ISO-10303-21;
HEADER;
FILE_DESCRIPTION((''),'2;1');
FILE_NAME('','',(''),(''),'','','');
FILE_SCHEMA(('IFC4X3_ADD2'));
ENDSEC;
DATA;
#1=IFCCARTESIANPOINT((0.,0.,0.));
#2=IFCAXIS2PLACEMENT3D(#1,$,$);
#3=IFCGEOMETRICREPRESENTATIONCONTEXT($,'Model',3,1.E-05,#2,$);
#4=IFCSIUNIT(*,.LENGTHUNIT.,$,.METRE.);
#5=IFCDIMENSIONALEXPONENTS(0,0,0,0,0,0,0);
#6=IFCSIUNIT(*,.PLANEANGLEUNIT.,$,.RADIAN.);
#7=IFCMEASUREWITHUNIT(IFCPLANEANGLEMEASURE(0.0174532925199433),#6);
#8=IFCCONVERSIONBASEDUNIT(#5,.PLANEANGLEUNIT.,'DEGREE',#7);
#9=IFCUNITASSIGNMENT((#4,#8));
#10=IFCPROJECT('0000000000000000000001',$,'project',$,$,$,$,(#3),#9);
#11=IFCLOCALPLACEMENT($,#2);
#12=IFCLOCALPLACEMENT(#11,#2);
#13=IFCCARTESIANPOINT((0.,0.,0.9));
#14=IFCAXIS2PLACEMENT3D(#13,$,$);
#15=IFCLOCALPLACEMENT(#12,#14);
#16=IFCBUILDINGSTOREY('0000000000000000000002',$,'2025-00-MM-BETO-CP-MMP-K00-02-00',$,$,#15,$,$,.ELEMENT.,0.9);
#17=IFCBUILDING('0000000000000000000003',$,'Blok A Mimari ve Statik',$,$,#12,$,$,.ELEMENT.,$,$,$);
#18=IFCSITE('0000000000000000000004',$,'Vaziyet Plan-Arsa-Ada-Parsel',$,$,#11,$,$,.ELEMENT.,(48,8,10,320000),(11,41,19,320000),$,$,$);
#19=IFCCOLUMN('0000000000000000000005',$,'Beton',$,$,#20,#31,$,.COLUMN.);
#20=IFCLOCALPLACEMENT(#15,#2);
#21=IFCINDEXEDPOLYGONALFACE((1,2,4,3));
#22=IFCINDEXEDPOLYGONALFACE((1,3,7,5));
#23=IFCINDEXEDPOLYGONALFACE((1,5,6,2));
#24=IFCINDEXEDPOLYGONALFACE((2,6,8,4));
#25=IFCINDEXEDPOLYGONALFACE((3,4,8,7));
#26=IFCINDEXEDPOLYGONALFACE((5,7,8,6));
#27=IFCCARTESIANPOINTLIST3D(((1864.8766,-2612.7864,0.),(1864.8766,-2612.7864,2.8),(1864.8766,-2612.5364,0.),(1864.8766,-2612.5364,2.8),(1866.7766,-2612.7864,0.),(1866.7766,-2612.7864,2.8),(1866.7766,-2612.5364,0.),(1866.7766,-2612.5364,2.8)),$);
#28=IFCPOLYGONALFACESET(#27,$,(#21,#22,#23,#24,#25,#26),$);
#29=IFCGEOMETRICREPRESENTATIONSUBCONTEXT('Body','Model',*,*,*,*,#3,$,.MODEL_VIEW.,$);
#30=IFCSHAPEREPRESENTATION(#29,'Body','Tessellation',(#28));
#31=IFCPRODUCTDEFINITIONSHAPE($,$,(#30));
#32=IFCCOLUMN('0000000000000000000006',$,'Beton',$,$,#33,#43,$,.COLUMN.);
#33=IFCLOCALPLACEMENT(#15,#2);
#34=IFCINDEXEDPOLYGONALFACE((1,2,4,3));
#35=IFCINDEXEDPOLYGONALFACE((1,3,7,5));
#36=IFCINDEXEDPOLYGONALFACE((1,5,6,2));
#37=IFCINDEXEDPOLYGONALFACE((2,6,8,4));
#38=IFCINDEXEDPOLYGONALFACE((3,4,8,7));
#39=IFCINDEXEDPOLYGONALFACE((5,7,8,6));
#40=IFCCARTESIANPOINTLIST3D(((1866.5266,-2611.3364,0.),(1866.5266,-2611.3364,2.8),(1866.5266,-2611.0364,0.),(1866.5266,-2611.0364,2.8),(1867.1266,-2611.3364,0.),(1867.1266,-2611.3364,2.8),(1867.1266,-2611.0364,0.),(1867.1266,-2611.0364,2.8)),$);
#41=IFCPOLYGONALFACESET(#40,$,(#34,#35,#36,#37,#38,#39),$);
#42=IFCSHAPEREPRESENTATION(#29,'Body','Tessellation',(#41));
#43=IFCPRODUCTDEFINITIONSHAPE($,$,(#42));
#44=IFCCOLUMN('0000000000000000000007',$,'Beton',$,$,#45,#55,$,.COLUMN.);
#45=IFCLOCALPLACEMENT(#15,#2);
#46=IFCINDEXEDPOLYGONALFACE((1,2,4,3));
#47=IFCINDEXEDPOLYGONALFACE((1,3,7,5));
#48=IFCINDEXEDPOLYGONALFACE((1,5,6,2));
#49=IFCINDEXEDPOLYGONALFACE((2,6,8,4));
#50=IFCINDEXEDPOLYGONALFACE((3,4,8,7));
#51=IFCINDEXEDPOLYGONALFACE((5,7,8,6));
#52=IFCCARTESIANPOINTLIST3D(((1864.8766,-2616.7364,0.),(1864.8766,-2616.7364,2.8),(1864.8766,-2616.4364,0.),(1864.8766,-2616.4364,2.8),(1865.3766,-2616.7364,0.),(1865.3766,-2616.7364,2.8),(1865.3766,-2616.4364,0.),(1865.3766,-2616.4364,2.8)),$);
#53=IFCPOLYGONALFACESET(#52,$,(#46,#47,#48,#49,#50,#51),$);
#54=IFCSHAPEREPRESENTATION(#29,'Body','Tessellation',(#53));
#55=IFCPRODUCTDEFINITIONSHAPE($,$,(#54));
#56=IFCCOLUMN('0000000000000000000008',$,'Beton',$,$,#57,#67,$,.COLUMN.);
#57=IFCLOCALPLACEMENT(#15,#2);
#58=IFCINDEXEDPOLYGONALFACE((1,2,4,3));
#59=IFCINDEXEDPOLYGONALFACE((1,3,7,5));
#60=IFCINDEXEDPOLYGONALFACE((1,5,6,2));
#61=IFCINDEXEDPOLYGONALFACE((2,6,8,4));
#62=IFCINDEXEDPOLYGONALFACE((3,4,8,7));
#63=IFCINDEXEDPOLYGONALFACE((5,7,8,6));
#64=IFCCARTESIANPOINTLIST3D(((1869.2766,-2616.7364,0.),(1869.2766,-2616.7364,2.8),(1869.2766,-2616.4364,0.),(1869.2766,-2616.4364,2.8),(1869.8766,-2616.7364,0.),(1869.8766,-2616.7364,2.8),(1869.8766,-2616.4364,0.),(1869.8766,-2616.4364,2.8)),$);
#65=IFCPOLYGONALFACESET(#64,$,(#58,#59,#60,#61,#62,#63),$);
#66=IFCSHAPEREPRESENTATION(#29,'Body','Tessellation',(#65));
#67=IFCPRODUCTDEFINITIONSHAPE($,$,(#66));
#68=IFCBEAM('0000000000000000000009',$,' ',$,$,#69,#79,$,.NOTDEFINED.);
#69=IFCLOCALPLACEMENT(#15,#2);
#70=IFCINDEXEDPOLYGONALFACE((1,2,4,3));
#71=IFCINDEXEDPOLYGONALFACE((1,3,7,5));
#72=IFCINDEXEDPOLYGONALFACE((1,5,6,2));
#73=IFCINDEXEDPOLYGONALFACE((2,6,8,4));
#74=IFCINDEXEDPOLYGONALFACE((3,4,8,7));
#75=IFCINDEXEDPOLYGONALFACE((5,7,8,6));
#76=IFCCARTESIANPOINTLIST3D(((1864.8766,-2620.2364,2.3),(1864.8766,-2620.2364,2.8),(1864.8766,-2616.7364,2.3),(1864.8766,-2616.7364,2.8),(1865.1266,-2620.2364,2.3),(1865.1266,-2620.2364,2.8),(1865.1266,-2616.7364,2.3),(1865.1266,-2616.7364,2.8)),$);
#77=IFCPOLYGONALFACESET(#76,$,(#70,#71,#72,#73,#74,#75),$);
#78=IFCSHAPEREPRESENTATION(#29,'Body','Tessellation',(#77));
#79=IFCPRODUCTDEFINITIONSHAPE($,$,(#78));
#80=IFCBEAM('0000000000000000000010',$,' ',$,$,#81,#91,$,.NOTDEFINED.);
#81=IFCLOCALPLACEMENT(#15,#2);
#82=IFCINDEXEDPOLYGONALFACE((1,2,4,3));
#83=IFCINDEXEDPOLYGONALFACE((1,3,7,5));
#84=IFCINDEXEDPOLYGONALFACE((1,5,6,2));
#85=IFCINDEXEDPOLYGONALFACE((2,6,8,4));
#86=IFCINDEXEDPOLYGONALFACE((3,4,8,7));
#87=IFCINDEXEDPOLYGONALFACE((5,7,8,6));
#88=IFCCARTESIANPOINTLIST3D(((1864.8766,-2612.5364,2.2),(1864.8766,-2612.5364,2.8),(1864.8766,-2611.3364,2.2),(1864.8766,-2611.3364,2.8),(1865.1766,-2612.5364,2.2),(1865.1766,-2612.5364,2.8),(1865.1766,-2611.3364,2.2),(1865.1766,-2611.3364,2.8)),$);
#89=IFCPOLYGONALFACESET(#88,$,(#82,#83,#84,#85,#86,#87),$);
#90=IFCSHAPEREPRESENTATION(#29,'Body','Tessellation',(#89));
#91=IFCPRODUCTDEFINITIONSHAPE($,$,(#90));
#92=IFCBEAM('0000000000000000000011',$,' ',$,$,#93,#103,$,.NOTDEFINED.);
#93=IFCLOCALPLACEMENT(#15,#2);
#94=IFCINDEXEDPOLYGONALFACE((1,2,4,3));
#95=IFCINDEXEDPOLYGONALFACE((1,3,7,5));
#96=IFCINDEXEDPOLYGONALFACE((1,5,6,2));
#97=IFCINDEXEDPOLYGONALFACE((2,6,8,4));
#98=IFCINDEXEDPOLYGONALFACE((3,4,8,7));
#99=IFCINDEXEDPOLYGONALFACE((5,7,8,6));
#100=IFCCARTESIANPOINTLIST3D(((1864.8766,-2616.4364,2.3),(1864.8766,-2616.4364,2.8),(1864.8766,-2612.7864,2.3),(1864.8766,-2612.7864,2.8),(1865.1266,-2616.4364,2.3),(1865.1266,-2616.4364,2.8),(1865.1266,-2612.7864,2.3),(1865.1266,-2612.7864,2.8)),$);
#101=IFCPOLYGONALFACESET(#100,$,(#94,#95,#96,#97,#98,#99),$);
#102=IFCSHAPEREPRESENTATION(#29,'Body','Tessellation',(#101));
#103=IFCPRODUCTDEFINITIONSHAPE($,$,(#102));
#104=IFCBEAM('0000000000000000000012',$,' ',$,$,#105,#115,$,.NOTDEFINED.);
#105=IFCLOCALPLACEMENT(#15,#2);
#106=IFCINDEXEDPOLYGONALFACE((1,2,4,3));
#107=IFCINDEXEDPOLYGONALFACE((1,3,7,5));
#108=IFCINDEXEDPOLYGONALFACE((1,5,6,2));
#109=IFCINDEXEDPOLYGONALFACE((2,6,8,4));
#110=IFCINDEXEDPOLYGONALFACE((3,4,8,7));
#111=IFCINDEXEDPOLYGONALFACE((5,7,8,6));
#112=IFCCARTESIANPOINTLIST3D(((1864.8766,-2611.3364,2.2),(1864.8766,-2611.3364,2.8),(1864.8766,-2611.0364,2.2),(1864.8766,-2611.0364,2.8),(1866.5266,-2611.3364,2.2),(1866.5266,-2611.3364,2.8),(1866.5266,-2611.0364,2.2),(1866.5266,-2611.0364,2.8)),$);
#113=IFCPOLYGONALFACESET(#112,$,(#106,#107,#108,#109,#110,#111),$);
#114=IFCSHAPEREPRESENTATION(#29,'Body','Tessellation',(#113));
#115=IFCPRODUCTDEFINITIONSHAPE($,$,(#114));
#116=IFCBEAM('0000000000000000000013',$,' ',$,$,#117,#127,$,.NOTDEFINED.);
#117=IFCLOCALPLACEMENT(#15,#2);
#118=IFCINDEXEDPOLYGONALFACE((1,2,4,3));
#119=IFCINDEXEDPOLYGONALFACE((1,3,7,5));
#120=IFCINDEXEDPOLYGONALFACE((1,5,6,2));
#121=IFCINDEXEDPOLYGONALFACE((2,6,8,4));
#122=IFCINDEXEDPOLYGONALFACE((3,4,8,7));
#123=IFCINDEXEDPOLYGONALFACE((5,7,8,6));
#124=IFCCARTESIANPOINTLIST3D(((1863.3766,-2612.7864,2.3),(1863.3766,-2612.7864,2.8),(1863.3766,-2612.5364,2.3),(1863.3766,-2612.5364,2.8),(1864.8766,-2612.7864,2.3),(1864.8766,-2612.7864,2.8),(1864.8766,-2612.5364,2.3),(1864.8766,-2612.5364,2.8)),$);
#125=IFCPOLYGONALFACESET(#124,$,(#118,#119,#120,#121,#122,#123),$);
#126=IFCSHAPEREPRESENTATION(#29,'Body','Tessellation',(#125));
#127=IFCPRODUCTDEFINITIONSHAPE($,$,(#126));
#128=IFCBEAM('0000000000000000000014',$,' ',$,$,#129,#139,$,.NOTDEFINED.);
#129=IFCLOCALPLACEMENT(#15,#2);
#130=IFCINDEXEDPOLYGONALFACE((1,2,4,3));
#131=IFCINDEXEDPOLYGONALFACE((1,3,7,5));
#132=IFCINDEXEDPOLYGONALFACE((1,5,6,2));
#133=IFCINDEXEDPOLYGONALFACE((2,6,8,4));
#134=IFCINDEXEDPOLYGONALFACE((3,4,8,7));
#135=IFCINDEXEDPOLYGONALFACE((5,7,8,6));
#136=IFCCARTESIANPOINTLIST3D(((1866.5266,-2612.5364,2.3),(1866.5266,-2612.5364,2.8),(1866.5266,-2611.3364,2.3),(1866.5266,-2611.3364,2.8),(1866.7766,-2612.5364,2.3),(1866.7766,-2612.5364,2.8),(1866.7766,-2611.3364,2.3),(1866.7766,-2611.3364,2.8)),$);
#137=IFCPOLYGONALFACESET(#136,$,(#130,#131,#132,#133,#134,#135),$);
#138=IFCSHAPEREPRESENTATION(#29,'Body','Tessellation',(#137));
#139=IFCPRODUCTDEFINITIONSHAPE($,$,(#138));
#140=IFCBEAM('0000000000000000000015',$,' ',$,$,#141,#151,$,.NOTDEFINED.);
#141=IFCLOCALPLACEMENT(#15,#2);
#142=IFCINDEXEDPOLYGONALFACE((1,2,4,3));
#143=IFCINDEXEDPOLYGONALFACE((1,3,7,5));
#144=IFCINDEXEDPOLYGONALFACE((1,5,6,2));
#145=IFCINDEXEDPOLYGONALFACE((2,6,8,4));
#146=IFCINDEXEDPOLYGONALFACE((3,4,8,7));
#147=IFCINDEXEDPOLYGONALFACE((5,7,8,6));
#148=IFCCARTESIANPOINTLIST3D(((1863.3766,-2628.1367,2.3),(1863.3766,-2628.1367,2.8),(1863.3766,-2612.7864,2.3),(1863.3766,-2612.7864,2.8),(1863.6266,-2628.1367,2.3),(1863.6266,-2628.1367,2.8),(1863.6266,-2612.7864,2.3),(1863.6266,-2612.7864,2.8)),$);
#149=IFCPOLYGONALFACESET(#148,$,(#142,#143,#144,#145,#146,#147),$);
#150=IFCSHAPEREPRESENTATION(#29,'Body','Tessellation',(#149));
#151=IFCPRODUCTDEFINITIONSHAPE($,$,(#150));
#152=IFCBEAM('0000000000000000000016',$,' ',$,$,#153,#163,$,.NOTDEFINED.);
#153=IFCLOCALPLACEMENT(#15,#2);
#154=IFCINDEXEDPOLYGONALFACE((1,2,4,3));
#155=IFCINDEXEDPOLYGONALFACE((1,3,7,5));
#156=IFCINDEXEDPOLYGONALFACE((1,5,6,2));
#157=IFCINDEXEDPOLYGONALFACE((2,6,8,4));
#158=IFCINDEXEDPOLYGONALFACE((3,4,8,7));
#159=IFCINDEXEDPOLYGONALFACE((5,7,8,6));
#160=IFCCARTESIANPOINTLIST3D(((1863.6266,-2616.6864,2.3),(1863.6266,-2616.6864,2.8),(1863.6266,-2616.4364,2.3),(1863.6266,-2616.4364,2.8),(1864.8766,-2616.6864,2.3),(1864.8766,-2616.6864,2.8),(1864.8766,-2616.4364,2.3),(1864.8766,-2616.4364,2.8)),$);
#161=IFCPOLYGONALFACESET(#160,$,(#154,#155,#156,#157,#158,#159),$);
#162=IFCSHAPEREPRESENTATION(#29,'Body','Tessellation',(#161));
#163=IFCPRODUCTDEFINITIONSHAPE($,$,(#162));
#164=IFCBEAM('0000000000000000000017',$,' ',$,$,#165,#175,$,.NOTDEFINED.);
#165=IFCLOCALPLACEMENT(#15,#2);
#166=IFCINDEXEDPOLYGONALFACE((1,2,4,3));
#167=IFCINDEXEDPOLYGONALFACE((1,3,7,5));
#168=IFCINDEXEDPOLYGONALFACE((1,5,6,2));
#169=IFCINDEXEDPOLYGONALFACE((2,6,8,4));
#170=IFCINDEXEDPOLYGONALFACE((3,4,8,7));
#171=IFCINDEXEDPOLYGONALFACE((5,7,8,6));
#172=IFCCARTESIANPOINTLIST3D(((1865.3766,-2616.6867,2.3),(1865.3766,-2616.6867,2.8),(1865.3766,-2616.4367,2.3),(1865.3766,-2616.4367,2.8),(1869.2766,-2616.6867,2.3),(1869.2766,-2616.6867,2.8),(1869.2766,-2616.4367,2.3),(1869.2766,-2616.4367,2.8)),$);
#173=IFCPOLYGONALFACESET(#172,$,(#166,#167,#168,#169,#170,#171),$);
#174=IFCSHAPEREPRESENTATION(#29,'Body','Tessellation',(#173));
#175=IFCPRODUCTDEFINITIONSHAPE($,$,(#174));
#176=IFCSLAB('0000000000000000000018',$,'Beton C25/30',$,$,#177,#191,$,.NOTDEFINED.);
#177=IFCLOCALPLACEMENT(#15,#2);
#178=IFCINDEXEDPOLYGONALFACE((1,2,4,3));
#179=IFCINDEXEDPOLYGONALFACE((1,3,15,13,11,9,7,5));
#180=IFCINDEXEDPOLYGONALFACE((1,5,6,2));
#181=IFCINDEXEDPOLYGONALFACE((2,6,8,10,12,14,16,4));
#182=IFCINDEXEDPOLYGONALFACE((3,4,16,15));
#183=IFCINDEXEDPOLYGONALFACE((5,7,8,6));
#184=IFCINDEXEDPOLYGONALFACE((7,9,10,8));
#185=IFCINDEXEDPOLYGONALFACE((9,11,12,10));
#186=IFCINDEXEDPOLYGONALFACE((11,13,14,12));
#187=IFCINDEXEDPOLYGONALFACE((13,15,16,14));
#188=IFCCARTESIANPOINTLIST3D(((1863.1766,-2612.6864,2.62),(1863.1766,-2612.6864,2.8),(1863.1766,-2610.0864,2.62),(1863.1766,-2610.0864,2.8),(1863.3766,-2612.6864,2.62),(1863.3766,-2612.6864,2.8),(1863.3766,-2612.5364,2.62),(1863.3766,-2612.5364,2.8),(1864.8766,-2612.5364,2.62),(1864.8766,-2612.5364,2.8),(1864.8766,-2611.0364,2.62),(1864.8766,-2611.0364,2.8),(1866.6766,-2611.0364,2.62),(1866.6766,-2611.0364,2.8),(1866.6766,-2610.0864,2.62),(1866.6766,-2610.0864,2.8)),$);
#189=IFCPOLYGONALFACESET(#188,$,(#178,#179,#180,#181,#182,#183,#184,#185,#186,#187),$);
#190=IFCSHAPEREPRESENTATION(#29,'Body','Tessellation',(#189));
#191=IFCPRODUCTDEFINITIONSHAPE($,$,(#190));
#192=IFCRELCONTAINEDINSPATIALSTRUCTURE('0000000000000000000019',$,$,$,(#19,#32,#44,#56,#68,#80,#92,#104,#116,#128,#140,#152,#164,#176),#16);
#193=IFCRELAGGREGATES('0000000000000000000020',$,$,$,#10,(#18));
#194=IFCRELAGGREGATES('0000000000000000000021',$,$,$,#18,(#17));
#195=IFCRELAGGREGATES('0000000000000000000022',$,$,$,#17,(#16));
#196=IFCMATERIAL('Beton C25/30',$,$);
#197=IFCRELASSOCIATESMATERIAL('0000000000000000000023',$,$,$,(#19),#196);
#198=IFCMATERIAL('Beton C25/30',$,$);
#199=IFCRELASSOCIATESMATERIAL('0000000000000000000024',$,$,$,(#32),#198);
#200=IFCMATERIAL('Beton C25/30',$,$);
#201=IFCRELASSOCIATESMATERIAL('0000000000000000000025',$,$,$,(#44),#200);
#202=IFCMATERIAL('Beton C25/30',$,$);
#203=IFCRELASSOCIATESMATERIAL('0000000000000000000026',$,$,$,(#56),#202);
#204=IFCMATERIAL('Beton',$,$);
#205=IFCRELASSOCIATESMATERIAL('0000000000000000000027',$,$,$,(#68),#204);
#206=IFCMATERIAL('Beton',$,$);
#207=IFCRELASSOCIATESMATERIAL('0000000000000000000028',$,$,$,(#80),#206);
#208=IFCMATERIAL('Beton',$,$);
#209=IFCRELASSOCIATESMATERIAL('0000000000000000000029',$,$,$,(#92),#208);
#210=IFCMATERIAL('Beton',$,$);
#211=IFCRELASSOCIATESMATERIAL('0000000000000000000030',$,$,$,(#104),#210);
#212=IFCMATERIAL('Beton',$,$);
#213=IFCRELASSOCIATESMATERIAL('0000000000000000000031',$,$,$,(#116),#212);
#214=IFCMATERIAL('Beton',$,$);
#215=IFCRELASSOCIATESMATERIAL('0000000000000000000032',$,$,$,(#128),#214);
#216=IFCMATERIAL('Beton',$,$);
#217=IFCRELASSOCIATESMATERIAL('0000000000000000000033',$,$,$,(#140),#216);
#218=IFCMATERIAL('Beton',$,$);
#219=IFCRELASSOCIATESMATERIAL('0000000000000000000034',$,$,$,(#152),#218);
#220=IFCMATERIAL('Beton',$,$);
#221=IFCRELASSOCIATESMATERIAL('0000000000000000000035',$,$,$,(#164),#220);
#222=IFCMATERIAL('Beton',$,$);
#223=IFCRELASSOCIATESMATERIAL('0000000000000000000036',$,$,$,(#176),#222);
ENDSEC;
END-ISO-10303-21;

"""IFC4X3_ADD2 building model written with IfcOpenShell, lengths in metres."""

from ifc_helpers import new_model, entity, si_unit, converted_unit, frame, frame_2d, origin, origin_with_axes, place, context, subcontext, project, spatial, polyline, rectangle, outline, extrude, material, element, save


model = new_model("IFC4X3_ADD2")

# Units and contexts
model_context = context("Model", 3, precision=1e-05, world=origin())
body_context = subcontext(model_context, "Body", "Model", "MODEL_VIEW")
ifc_project = project(units=[si_unit("LENGTHUNIT", "METRE"), converted_unit("PLANEANGLEUNIT", "DEGREE", entity("IfcPlaneAngleMeasure", 0.0174532925199433), si_unit("PLANEANGLEUNIT", "RADIAN"), dimensions=[0, 0, 0, 0, 0, 0, 0])], contexts=[model_context])

# Site, building, storey
site_placement = place(None, origin())
site = spatial("IfcSite", under=ifc_project, at=site_placement, Name="Vaziyet Plan-Arsa-Ada-Parsel", CompositionType="ELEMENT", RefLatitude=(48, 8, 10, 320000), RefLongitude=(11, 41, 19, 320000))
building_placement = place(site_placement, origin())
building = spatial("IfcBuilding", under=site, at=building_placement, Name="Blok A Mimari ve Statik", CompositionType="ELEMENT")
storey_placement = place(building_placement, frame((0.0, 0.0, 0.9)))
storey = spatial("IfcBuildingStorey", under=building, at=storey_placement, Name="2025-00-MM-BETO-CP-MMP-K00-02-00", CompositionType="ELEMENT", Elevation=0.9)

# Columns
ifc_material_1 = material(Name="Beton C25/30")
column_1_placement = place(storey_placement, frame((1864.8766, -2612.7864, 0.0)))
element("IfcColumn", 1, at=column_1_placement, inside=storey, material=ifc_material_1, Name="Beton", PredefinedType="COLUMN", context=body_context, shape_type="SweptSolid", body=[
    extrude(outline(polyline([(0.0, 0.0), (1.9, 0.0), (1.9, 0.25), (0.0, 0.25), (0.0, 0.0)])), origin_with_axes(), (0.0, 0.0, 1.0), 2.8),
])
ifc_material_2 = material(Name="Beton C25/30")
column_2_placement = place(storey_placement, frame((1866.5266, -2611.3364, 0.0)))
element("IfcColumn", 2, at=column_2_placement, inside=storey, material=ifc_material_2, Name="Beton", PredefinedType="COLUMN", context=body_context, shape_type="SweptSolid", body=[
    extrude(outline(polyline([(0.0, 0.0), (0.6, 0.0), (0.6, 0.3), (0.0, 0.3), (0.0, 0.0)])), origin_with_axes(), (0.0, 0.0, 1.0), 2.8),
])
ifc_material_3 = material(Name="Beton C25/30")
column_3_placement = place(storey_placement, frame((1864.8766, -2616.7364, 0.0)))
element("IfcColumn", 3, at=column_3_placement, inside=storey, material=ifc_material_3, Name="Beton", PredefinedType="COLUMN", context=body_context, shape_type="SweptSolid", body=[
    extrude(outline(polyline([(0.0, 0.0), (0.5, 0.0), (0.5, 0.3), (0.0, 0.3), (0.0, 0.0)])), origin_with_axes(), (0.0, 0.0, 1.0), 2.8),
])
ifc_material_4 = material(Name="Beton C25/30")
column_4_placement = place(storey_placement, frame((1869.2766, -2616.7364, 0.0)))
element("IfcColumn", 4, at=column_4_placement, inside=storey, material=ifc_material_4, Name="Beton", PredefinedType="COLUMN", context=body_context, shape_type="SweptSolid", body=[
    extrude(outline(polyline([(0.0, 0.0), (0.6, 0.0), (0.6, 0.3), (0.0, 0.3), (0.0, 0.0)])), origin_with_axes(), (0.0, 0.0, 1.0), 2.8),
])

# Beams
ifc_material_5 = material(Name="Beton")
beam_1_placement = place(storey_placement, frame((1864.8766, -2616.7364, 2.3), z_axis=(0.0, 0.0, 1.0), x_axis=(0.0, -1.0, 0.0)))
element("IfcBeam", 5, at=beam_1_placement, inside=storey, material=ifc_material_5, Name=" ", PredefinedType="NOTDEFINED", context=body_context, shape_type="SweptSolid", body=[
    extrude(rectangle(XDim=0.25, YDim=0.5, at=frame_2d((0.125, 0.25), x_axis=(1.0, 0.0))), frame((0.0, 0.0, 0.0), z_axis=(1.0, 0.0, 0.0), x_axis=(0.0, 1.0, 0.0)), (0.0, 0.0, 1.0), 3.5),
])
ifc_material_6 = material(Name="Beton")
beam_2_placement = place(storey_placement, frame((1864.8766, -2611.3364, 2.2), z_axis=(0.0, 0.0, 1.0), x_axis=(0.0, -1.0, 0.0)))
element("IfcBeam", 6, at=beam_2_placement, inside=storey, material=ifc_material_6, Name=" ", PredefinedType="NOTDEFINED", context=body_context, shape_type="SweptSolid", body=[
    extrude(rectangle(XDim=0.3, YDim=0.6, at=frame_2d((0.15, 0.3), x_axis=(1.0, 0.0))), frame((0.0, 0.0, 0.0), z_axis=(1.0, 0.0, 0.0), x_axis=(0.0, 1.0, 0.0)), (0.0, 0.0, 1.0), 1.2),
])
ifc_material_7 = material(Name="Beton")
beam_3_placement = place(storey_placement, frame((1864.8766, -2612.7864, 2.3), z_axis=(0.0, 0.0, 1.0), x_axis=(0.0, -1.0, 0.0)))
element("IfcBeam", 7, at=beam_3_placement, inside=storey, material=ifc_material_7, Name=" ", PredefinedType="NOTDEFINED", context=body_context, shape_type="SweptSolid", body=[
    extrude(rectangle(XDim=0.25, YDim=0.5, at=frame_2d((0.125, 0.25), x_axis=(1.0, 0.0))), frame((0.0, 0.0, 0.0), z_axis=(1.0, 0.0, 0.0), x_axis=(0.0, 1.0, 0.0)), (0.0, 0.0, 1.0), 3.65),
])
ifc_material_8 = material(Name="Beton")
beam_4_placement = place(storey_placement, frame((1866.5266, -2611.0364, 2.2), z_axis=(0.0, 0.0, 1.0), x_axis=(-1.0, 0.0, 0.0)))
element("IfcBeam", 8, at=beam_4_placement, inside=storey, material=ifc_material_8, Name=" ", PredefinedType="NOTDEFINED", context=body_context, shape_type="SweptSolid", body=[
    extrude(rectangle(XDim=0.3, YDim=0.6, at=frame_2d((0.15, 0.3), x_axis=(1.0, 0.0))), frame((0.0, 0.0, 0.0), z_axis=(1.0, 0.0, 0.0), x_axis=(0.0, 1.0, 0.0)), (0.0, 0.0, 1.0), 1.65),
])
ifc_material_9 = material(Name="Beton")
beam_5_placement = place(storey_placement, frame((1864.8766, -2612.5364, 2.3), z_axis=(0.0, 0.0, 1.0), x_axis=(-1.0, 0.0, 0.0)))
element("IfcBeam", 9, at=beam_5_placement, inside=storey, material=ifc_material_9, Name=" ", PredefinedType="NOTDEFINED", context=body_context, shape_type="SweptSolid", body=[
    extrude(rectangle(XDim=0.25, YDim=0.5, at=frame_2d((0.125, 0.25), x_axis=(1.0, 0.0))), frame((0.0, 0.0, 0.0), z_axis=(1.0, 0.0, 0.0), x_axis=(0.0, 1.0, 0.0)), (0.0, 0.0, 1.0), 1.5),
])
ifc_material_10 = material(Name="Beton")
beam_6_placement = place(storey_placement, frame((1866.5266, -2611.3364, 2.3), z_axis=(0.0, 0.0, 1.0), x_axis=(0.0, -1.0, 0.0)))
element("IfcBeam", 10, at=beam_6_placement, inside=storey, material=ifc_material_10, Name=" ", PredefinedType="NOTDEFINED", context=body_context, shape_type="SweptSolid", body=[
    extrude(rectangle(XDim=0.25, YDim=0.5, at=frame_2d((0.125, 0.25), x_axis=(1.0, 0.0))), frame((0.0, 0.0, 0.0), z_axis=(1.0, 0.0, 0.0), x_axis=(0.0, 1.0, 0.0)), (0.0, 0.0, 1.0), 1.2),
])
ifc_material_11 = material(Name="Beton")
beam_7_placement = place(storey_placement, frame((1863.3766, -2612.7864, 2.3), z_axis=(0.0, 0.0, 1.0), x_axis=(0.0, -1.0, 0.0)))
element("IfcBeam", 11, at=beam_7_placement, inside=storey, material=ifc_material_11, Name=" ", PredefinedType="NOTDEFINED", context=body_context, shape_type="SweptSolid", body=[
    extrude(rectangle(XDim=0.25, YDim=0.5, at=frame_2d((0.125, 0.25), x_axis=(1.0, 0.0))), frame((0.0, 0.0, 0.0), z_axis=(1.0, 0.0, 0.0), x_axis=(0.0, 1.0, 0.0)), (0.0, 0.0, 1.0), 15.3503),
])
ifc_material_12 = material(Name="Beton")
beam_8_placement = place(storey_placement, frame((1863.6266, -2616.6864, 2.3)))
element("IfcBeam", 12, at=beam_8_placement, inside=storey, material=ifc_material_12, Name=" ", PredefinedType="NOTDEFINED", context=body_context, shape_type="SweptSolid", body=[
    extrude(rectangle(XDim=0.25, YDim=0.5, at=frame_2d((0.125, 0.25), x_axis=(1.0, 0.0))), frame((0.0, 0.0, 0.0), z_axis=(1.0, 0.0, 0.0), x_axis=(0.0, 1.0, 0.0)), (0.0, 0.0, 1.0), 1.25),
])
ifc_material_13 = material(Name="Beton")
beam_9_placement = place(storey_placement, frame((1865.3766, -2616.6867, 2.3)))
element("IfcBeam", 13, at=beam_9_placement, inside=storey, material=ifc_material_13, Name=" ", PredefinedType="NOTDEFINED", context=body_context, shape_type="SweptSolid", body=[
    extrude(rectangle(XDim=0.25, YDim=0.5, at=frame_2d((0.125, 0.25), x_axis=(1.0, 0.0))), frame((0.0, 0.0, 0.0), z_axis=(1.0, 0.0, 0.0), x_axis=(0.0, 1.0, 0.0)), (0.0, 0.0, 1.0), 3.9),
])

# Slab
ifc_material_14 = material(Name="Beton")
slab_1_placement = place(storey_placement, frame((1863.1766, -2612.6864, 2.62)))
element("IfcSlab", 14, at=slab_1_placement, inside=storey, material=ifc_material_14, Name="Beton C25/30", PredefinedType="NOTDEFINED", context=body_context, shape_type="SweptSolid", body=[
    extrude(outline(polyline([(3.5, 1.65), (3.5, 2.6), (0.0, 2.6), (0.0, 0.0), (0.2, 0.0), (0.2, 0.15), (1.7, 0.15), (1.7, 1.65), (3.5, 1.65)])), origin_with_axes(), (0.0, 0.0, 1.0), 0.18),
])

save(model, "model.ifc")
